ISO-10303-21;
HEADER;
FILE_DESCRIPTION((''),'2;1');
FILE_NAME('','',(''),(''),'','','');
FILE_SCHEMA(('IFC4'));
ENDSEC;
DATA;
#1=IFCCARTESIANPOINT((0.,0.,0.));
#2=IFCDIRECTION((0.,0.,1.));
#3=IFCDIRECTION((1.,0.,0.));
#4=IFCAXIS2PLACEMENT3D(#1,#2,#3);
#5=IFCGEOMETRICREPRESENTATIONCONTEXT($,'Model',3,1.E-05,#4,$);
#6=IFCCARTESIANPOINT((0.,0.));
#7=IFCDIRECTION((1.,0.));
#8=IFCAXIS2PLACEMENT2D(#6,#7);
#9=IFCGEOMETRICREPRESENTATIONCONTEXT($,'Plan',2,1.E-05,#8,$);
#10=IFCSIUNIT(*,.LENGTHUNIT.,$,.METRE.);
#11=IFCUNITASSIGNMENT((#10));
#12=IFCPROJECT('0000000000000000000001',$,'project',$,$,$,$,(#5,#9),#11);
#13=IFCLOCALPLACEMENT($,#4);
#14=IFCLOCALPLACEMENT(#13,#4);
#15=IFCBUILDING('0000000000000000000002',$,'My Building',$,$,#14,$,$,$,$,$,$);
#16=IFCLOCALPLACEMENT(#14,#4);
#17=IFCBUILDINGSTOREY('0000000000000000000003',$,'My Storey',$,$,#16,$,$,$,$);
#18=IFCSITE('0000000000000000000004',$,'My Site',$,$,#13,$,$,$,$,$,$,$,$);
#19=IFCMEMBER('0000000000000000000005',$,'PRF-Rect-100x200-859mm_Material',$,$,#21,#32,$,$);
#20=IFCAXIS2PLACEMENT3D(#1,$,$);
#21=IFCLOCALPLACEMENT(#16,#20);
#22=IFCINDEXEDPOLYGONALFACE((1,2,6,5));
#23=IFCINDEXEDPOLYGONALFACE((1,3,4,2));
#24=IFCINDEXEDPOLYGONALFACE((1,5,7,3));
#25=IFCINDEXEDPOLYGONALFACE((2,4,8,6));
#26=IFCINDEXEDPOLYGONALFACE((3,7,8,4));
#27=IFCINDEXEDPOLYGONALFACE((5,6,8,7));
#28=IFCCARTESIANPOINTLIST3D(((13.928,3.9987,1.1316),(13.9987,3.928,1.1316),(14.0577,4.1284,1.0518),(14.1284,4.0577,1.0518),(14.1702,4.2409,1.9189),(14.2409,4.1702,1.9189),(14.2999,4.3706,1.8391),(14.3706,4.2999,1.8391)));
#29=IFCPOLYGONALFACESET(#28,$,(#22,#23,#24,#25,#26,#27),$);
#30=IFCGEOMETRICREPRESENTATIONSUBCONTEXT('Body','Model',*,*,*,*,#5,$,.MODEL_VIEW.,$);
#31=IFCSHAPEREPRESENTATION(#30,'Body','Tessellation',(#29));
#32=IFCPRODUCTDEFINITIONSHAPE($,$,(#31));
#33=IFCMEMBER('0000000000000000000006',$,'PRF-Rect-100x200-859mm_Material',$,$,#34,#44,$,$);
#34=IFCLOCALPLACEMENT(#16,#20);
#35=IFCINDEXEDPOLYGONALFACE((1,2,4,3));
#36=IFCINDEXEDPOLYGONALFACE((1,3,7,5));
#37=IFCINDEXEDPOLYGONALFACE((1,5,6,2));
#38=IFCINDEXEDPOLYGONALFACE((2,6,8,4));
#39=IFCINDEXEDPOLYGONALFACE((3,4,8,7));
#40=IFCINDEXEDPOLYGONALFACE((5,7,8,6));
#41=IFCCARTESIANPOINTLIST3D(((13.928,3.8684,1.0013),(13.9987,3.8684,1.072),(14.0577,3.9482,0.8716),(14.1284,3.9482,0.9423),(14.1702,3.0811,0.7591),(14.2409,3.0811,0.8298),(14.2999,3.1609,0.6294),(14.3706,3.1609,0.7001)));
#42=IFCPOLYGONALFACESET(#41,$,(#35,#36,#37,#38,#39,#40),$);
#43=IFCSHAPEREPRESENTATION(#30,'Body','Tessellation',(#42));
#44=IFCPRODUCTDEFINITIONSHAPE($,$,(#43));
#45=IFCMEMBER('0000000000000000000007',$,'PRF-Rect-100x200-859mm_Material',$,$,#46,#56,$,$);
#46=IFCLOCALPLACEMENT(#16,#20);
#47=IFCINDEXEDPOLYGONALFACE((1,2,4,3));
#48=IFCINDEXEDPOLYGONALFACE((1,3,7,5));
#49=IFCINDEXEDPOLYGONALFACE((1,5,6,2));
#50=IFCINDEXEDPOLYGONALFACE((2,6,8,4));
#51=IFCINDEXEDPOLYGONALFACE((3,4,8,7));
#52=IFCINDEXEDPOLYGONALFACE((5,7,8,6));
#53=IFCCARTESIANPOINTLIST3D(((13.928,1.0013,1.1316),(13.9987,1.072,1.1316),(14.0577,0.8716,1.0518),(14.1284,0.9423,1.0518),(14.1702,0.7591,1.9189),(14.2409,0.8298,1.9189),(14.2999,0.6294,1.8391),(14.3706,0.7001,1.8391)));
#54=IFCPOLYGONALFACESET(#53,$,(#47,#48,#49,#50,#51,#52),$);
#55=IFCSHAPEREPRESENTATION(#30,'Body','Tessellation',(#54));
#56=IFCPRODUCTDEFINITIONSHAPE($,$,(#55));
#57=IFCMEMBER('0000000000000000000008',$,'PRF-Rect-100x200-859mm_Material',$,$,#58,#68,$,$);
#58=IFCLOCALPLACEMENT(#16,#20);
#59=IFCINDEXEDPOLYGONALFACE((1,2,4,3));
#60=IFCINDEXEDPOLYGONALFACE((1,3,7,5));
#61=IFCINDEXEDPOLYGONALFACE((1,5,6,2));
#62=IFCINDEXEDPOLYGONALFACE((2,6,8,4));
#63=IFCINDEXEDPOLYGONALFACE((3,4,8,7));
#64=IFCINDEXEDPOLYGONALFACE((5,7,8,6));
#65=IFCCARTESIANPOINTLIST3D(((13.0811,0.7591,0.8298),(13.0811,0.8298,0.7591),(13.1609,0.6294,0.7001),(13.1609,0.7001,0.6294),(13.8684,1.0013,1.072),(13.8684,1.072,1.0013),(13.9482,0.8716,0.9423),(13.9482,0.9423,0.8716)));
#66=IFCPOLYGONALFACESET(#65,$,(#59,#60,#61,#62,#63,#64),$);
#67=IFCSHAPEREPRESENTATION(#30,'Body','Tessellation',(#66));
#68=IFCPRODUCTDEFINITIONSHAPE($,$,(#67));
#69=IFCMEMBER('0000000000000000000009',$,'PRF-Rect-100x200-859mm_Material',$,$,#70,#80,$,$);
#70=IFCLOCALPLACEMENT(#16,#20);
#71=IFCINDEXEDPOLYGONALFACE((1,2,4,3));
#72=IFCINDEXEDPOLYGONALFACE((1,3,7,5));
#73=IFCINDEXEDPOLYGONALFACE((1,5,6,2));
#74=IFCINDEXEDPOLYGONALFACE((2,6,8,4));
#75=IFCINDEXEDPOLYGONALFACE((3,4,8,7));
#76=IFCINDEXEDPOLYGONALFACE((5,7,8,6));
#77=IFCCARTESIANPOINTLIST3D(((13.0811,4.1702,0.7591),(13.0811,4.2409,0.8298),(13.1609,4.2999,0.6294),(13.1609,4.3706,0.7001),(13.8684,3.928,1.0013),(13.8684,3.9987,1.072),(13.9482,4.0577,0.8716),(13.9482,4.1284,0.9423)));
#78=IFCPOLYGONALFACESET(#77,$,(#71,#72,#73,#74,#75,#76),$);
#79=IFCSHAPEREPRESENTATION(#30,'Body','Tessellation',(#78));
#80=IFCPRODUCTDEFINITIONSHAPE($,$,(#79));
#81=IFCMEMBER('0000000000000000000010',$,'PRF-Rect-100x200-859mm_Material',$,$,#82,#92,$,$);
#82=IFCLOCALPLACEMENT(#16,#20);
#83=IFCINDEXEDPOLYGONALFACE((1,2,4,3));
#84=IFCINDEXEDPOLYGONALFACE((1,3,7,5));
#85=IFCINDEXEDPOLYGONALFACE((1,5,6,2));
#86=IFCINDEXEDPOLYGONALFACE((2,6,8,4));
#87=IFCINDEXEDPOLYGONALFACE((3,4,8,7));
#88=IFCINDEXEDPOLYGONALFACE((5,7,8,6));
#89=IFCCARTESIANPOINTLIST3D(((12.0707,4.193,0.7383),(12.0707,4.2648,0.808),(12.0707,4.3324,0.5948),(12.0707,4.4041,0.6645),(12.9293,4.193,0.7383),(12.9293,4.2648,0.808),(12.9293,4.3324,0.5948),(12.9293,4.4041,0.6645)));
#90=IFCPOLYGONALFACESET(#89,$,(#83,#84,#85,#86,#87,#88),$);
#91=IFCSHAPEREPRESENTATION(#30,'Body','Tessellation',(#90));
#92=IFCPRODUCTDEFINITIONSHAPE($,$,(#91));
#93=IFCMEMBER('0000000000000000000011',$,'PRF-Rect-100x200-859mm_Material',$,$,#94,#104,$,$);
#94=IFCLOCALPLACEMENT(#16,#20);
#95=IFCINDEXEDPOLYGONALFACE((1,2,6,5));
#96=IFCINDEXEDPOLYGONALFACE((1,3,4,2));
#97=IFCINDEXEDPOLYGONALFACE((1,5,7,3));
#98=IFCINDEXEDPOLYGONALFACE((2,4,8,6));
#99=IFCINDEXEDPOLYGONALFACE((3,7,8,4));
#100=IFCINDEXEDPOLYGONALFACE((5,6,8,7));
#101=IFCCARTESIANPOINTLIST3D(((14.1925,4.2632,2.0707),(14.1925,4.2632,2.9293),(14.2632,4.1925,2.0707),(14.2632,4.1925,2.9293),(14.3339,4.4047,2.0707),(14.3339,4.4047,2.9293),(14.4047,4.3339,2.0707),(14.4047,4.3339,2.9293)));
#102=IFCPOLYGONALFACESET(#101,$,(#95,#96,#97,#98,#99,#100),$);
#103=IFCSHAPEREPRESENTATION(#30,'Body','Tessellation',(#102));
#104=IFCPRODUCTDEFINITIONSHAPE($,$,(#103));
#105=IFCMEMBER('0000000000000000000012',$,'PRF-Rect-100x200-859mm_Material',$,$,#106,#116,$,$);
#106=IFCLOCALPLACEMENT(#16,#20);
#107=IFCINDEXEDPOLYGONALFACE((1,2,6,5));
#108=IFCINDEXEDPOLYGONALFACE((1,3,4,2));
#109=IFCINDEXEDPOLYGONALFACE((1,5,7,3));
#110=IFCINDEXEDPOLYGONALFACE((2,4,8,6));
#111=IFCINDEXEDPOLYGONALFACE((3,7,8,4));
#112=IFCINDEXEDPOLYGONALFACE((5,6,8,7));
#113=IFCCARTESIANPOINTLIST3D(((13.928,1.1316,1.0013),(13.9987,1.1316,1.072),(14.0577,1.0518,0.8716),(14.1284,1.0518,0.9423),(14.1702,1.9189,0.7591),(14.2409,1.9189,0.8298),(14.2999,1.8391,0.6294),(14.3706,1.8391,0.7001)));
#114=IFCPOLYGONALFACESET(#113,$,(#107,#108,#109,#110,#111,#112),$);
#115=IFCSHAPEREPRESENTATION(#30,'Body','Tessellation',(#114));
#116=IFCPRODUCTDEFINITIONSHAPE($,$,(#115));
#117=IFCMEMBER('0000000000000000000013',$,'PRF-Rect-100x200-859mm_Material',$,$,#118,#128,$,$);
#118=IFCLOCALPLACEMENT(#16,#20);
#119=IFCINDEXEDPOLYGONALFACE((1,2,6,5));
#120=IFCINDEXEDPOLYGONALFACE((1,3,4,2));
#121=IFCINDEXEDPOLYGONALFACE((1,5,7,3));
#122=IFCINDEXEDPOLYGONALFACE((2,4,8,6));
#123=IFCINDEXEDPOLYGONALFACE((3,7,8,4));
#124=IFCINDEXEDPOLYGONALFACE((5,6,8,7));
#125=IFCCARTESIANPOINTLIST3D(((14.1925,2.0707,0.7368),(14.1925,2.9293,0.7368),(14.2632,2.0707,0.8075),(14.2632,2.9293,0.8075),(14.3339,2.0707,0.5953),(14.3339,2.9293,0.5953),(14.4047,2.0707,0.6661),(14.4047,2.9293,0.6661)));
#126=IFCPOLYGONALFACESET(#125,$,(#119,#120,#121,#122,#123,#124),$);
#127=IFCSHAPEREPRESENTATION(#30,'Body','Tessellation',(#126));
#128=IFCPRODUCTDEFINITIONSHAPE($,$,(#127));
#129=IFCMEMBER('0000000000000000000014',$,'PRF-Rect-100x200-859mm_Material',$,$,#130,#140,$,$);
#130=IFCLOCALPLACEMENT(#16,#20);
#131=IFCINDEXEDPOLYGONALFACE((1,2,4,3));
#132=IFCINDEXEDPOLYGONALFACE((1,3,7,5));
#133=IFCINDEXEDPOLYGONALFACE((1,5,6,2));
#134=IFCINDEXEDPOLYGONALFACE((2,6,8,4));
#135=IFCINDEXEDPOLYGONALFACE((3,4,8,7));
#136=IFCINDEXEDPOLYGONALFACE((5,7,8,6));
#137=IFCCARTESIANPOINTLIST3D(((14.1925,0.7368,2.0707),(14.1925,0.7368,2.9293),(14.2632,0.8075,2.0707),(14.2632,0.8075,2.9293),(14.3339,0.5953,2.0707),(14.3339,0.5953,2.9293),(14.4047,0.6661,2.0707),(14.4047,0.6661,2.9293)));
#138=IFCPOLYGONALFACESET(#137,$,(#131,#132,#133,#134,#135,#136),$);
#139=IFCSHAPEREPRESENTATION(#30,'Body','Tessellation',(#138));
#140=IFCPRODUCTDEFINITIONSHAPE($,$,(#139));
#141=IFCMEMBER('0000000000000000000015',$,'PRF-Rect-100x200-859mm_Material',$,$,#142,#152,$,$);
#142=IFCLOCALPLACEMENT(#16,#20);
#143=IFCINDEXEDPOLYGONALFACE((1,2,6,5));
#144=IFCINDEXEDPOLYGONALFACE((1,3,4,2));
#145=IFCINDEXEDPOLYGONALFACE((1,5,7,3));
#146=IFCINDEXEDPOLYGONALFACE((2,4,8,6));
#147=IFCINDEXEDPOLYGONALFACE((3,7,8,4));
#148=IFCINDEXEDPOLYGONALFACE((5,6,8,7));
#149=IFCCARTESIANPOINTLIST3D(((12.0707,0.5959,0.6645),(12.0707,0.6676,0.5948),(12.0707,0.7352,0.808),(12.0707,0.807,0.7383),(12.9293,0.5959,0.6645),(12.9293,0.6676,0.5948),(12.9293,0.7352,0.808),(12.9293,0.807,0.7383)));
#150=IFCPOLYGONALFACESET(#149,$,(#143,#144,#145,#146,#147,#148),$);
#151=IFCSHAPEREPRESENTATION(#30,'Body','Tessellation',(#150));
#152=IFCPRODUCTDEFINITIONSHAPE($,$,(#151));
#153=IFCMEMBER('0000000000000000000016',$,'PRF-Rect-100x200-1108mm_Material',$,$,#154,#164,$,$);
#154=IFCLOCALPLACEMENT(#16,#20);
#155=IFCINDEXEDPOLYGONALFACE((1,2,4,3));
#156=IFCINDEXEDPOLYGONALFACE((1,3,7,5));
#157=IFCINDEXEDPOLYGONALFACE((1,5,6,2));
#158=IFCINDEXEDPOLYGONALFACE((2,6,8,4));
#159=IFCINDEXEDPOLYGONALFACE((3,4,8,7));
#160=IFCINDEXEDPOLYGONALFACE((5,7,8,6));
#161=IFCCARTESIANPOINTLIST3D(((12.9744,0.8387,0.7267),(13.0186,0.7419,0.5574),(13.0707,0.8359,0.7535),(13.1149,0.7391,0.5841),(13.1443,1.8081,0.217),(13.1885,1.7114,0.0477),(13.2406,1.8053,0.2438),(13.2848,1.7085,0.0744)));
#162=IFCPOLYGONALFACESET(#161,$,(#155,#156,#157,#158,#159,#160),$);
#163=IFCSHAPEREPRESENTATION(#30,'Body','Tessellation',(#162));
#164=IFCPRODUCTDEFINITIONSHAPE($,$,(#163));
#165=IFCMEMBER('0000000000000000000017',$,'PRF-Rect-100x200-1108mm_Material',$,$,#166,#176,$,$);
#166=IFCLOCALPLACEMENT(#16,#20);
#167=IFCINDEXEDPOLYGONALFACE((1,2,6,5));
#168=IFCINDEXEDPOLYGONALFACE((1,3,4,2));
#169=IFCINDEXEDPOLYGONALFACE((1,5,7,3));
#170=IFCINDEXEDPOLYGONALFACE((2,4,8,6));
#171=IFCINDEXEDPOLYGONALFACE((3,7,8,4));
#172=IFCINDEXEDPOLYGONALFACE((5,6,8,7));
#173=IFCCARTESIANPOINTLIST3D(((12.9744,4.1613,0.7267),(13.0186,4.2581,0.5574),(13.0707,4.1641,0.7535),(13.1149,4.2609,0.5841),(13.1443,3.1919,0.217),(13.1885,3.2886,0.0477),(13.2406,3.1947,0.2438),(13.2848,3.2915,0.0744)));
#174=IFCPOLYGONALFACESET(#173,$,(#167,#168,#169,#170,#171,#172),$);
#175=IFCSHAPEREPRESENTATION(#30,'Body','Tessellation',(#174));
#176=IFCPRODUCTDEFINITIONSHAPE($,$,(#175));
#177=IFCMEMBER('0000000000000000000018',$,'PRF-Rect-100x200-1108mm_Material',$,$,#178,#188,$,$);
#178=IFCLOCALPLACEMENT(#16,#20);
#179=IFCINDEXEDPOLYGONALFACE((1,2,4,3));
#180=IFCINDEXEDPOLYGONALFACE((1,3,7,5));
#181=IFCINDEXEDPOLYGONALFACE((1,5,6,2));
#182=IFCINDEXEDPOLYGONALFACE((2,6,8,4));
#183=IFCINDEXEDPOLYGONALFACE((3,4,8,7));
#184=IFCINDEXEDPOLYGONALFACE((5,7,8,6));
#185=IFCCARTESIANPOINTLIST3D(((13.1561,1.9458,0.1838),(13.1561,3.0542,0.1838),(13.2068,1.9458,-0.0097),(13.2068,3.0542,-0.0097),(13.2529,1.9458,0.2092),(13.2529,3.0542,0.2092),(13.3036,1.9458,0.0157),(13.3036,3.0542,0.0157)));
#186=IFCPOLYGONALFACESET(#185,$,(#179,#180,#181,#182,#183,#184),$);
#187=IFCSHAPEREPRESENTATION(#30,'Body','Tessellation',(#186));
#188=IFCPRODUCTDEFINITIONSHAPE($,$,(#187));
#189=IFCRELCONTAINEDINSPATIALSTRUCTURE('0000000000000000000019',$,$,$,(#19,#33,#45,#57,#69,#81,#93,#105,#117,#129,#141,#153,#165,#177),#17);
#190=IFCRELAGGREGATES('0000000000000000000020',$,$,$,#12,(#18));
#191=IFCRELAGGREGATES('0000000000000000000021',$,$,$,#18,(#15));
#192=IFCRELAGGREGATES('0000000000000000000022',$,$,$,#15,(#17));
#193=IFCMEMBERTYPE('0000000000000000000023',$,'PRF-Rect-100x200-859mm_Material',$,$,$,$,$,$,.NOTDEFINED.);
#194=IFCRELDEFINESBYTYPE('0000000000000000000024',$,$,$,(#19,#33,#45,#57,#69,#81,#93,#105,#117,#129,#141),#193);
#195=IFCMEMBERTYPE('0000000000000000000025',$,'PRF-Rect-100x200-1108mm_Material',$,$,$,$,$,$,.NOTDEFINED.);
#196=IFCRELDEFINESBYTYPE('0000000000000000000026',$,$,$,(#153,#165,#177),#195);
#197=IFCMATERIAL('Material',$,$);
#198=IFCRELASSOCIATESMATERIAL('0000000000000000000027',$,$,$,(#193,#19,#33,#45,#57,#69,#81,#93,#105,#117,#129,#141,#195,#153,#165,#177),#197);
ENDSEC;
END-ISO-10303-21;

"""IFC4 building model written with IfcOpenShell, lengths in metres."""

from ifc_helpers import new_model, si_unit, frame, origin, origin_with_axes, origin_2d_with_axis, place, context, subcontext, project, spatial, rectangle, extrude, material, material_profile, profile_set, profile_usage, type_object, element, save


model = new_model("IFC4")

# Units and contexts
model_context = context("Model", 3, precision=1e-05, world=origin_with_axes())
plan_context = context("Plan", 2, precision=1e-05, world=origin_2d_with_axis())
body_context = subcontext(model_context, "Body", "Model", "MODEL_VIEW")
ifc_project = project(units=[si_unit("LENGTHUNIT", "METRE")], contexts=[model_context, plan_context])

# Site, building, storey
site_placement = place(None, origin_with_axes())
site = spatial("IfcSite", under=ifc_project, at=site_placement, Name="My Site")
building_placement = place(site_placement, origin_with_axes())
building = spatial("IfcBuilding", under=site, at=building_placement, Name="My Building")
storey_placement = place(building_placement, origin_with_axes())
storey = spatial("IfcBuildingStorey", under=building, at=storey_placement, Name="My Storey")

# Members
ifc_material = material(Name="Material")
ifc_material_profile_1 = material_profile(ifc_material, rectangle(XDim=0.1, YDim=0.2))
ifc_profile_set_1 = profile_set([ifc_material_profile_1], Name="PRF-Rect-100x200-859mm_Material")
ifc_profile_usage_1 = profile_usage(ifc_profile_set_1, cardinal=5)
member_type_1 = type_object("IfcMemberType", Name="PRF-Rect-100x200-859mm_Material", PredefinedType="NOTDEFINED", material=ifc_profile_set_1)
member_1_placement = place(storey_placement, frame((14.2704, 4.2704, 1.879), z_axis=(-0.282067, -0.282066, -0.916993), x_axis=(-0.707107, 0.707107, 0.0)))
element("IfcMember", 1, at=member_1_placement, inside=storey, type_object=member_type_1, material=ifc_profile_usage_1, Name="PRF-Rect-100x200-859mm_Material", context=body_context, shape_type="SweptSolid", body=[
    extrude(rectangle(XDim=0.1, YDim=0.2), origin(), (0.0, 0.0, 1.0), 0.8586),
])
ifc_profile_usage_2 = profile_usage(ifc_profile_set_1, cardinal=5)
member_2_placement = place(storey_placement, frame((14.2704, 3.121, 0.7296), z_axis=(-0.282066, 0.916993, 0.282066), x_axis=(0.707107, 0.0, 0.707107)))
element("IfcMember", 2, at=member_2_placement, inside=storey, type_object=member_type_1, material=ifc_profile_usage_2, Name="PRF-Rect-100x200-859mm_Material", context=body_context, shape_type="SweptSolid", body=[
    extrude(rectangle(XDim=0.1, YDim=0.2), origin(), (0.0, 0.0, 1.0), 0.8586),
])
ifc_profile_usage_3 = profile_usage(ifc_profile_set_1, cardinal=5)
member_3_placement = place(storey_placement, frame((14.2704, 0.7296, 1.879), z_axis=(-0.282066, 0.282067, -0.916993), x_axis=(0.707107, 0.707107, 0.0)))
element("IfcMember", 3, at=member_3_placement, inside=storey, type_object=member_type_1, material=ifc_profile_usage_3, Name="PRF-Rect-100x200-859mm_Material", context=body_context, shape_type="SweptSolid", body=[
    extrude(rectangle(XDim=0.1, YDim=0.2), origin(), (0.0, 0.0, 1.0), 0.8586),
])
ifc_profile_usage_4 = profile_usage(ifc_profile_set_1, cardinal=5)
member_4_placement = place(storey_placement, frame((13.121, 0.7296, 0.7296), z_axis=(0.916994, 0.282066, 0.282066), x_axis=(0.0, -0.707107, 0.707107)))
element("IfcMember", 4, at=member_4_placement, inside=storey, type_object=member_type_1, material=ifc_profile_usage_4, Name="PRF-Rect-100x200-859mm_Material", context=body_context, shape_type="SweptSolid", body=[
    extrude(rectangle(XDim=0.1, YDim=0.2), origin(), (0.0, 0.0, 1.0), 0.8586),
])
ifc_profile_usage_5 = profile_usage(ifc_profile_set_1, cardinal=5)
member_5_placement = place(storey_placement, frame((13.9083, 4.0282, 0.9718), z_axis=(-0.916993, 0.282066, -0.282066), x_axis=(0.0, 0.707107, 0.707107)))
element("IfcMember", 5, at=member_5_placement, inside=storey, type_object=member_type_1, material=ifc_profile_usage_5, Name="PRF-Rect-100x200-859mm_Material", context=body_context, shape_type="SweptSolid", body=[
    extrude(rectangle(XDim=0.1, YDim=0.2), origin(), (0.0, 0.0, 1.0), 0.8586),
])
ifc_profile_usage_6 = profile_usage(ifc_profile_set_1, cardinal=5)
member_6_placement = place(storey_placement, frame((12.9293, 4.2986, 0.7014), z_axis=(-1.0, 0.0, 0.0), x_axis=(0.0, 0.717183, 0.696884)))
element("IfcMember", 6, at=member_6_placement, inside=storey, type_object=member_type_1, material=ifc_profile_usage_6, Name="PRF-Rect-100x200-859mm_Material", context=body_context, shape_type="SweptSolid", body=[
    extrude(rectangle(XDim=0.1, YDim=0.2), origin(), (0.0, 0.0, 1.0), 0.8586),
])
ifc_profile_usage_7 = profile_usage(ifc_profile_set_1, cardinal=5)
member_7_placement = place(storey_placement, frame((14.2986, 4.2986, 2.9293), z_axis=(0.0, 0.0, -1.0), x_axis=(-0.707107, 0.707107, 0.0)))
element("IfcMember", 7, at=member_7_placement, inside=storey, type_object=member_type_1, material=ifc_profile_usage_7, Name="PRF-Rect-100x200-859mm_Material", context=body_context, shape_type="SweptSolid", body=[
    extrude(rectangle(XDim=0.1, YDim=0.2), origin(), (0.0, 0.0, 1.0), 0.8586),
])
ifc_profile_usage_8 = profile_usage(ifc_profile_set_1, cardinal=5)
member_8_placement = place(storey_placement, frame((14.0282, 1.0917, 0.9718), z_axis=(0.282066, 0.916993, -0.282067), x_axis=(0.707107, 0.0, 0.707107)))
element("IfcMember", 8, at=member_8_placement, inside=storey, type_object=member_type_1, material=ifc_profile_usage_8, Name="PRF-Rect-100x200-859mm_Material", context=body_context, shape_type="SweptSolid", body=[
    extrude(rectangle(XDim=0.1, YDim=0.2), origin(), (0.0, 0.0, 1.0), 0.8586),
])
ifc_profile_usage_9 = profile_usage(ifc_profile_set_1, cardinal=5)
member_9_placement = place(storey_placement, frame((14.2986, 2.0707, 0.7014), z_axis=(0.0, 1.0, 0.0), x_axis=(0.707107, 0.0, 0.707107)))
element("IfcMember", 9, at=member_9_placement, inside=storey, type_object=member_type_1, material=ifc_profile_usage_9, Name="PRF-Rect-100x200-859mm_Material", context=body_context, shape_type="SweptSolid", body=[
    extrude(rectangle(XDim=0.1, YDim=0.2), origin(), (0.0, 0.0, 1.0), 0.8586),
])
ifc_profile_usage_10 = profile_usage(ifc_profile_set_1, cardinal=5)
member_10_placement = place(storey_placement, frame((14.2986, 0.7014, 2.9293), z_axis=(0.0, 0.0, -1.0), x_axis=(0.707107, 0.707107, 0.0)))
element("IfcMember", 10, at=member_10_placement, inside=storey, type_object=member_type_1, material=ifc_profile_usage_10, Name="PRF-Rect-100x200-859mm_Material", context=body_context, shape_type="SweptSolid", body=[
    extrude(rectangle(XDim=0.1, YDim=0.2), origin(), (0.0, 0.0, 1.0), 0.8586),
])
ifc_profile_usage_11 = profile_usage(ifc_profile_set_1, cardinal=5)
member_11_placement = place(storey_placement, frame((12.0707, 0.7014, 0.7014), z_axis=(1.0, 0.0, 0.0), x_axis=(0.0, -0.717183, 0.696885)))
element("IfcMember", 11, at=member_11_placement, inside=storey, type_object=member_type_1, material=ifc_profile_usage_11, Name="PRF-Rect-100x200-859mm_Material", context=body_context, shape_type="SweptSolid", body=[
    extrude(rectangle(XDim=0.1, YDim=0.2), origin(), (0.0, 0.0, 1.0), 0.8586),
])
ifc_material_profile_2 = material_profile(ifc_material, rectangle(XDim=0.1, YDim=0.2))
ifc_profile_set_2 = profile_set([ifc_material_profile_2], Name="PRF-Rect-100x200-1108mm_Material")
ifc_profile_usage_12 = profile_usage(ifc_profile_set_2, cardinal=5)
member_type_2 = type_object("IfcMemberType", Name="PRF-Rect-100x200-1108mm_Material", PredefinedType="NOTDEFINED", material=ifc_profile_set_2)
member_12_placement = place(storey_placement, frame((13.2145, 1.7583, 0.1457), z_axis=(-0.153283, -0.874667, 0.459849), x_axis=(-0.963147, 0.028153, -0.2675)))
element("IfcMember", 12, at=member_12_placement, inside=storey, type_object=member_type_2, material=ifc_profile_usage_12, Name="PRF-Rect-100x200-1108mm_Material", context=body_context, shape_type="SweptSolid", body=[
    extrude(rectangle(XDim=0.1, YDim=0.2), origin(), (0.0, 0.0, 1.0), 1.1084),
])
ifc_profile_usage_13 = profile_usage(ifc_profile_set_2, cardinal=5)
member_13_placement = place(storey_placement, frame((13.0446, 4.2111, 0.6554), z_axis=(0.153283, -0.874668, -0.459849), x_axis=(-0.963147, -0.028153, -0.2675)))
element("IfcMember", 13, at=member_13_placement, inside=storey, type_object=member_type_2, material=ifc_profile_usage_13, Name="PRF-Rect-100x200-1108mm_Material", context=body_context, shape_type="SweptSolid", body=[
    extrude(rectangle(XDim=0.1, YDim=0.2), origin(), (0.0, 0.0, 1.0), 1.1084),
])
ifc_profile_usage_14 = profile_usage(ifc_profile_set_2, cardinal=5)
member_14_placement = place(storey_placement, frame((13.2298, 3.0542, 0.0998), z_axis=(0.0, -1.0, 0.0), x_axis=(-0.967317, 0.0, -0.253569)))
element("IfcMember", 14, at=member_14_placement, inside=storey, type_object=member_type_2, material=ifc_profile_usage_14, Name="PRF-Rect-100x200-1108mm_Material", context=body_context, shape_type="SweptSolid", body=[
    extrude(rectangle(XDim=0.1, YDim=0.2), origin(), (0.0, 0.0, 1.0), 1.1084),
])

save(model, "model.ifc")
